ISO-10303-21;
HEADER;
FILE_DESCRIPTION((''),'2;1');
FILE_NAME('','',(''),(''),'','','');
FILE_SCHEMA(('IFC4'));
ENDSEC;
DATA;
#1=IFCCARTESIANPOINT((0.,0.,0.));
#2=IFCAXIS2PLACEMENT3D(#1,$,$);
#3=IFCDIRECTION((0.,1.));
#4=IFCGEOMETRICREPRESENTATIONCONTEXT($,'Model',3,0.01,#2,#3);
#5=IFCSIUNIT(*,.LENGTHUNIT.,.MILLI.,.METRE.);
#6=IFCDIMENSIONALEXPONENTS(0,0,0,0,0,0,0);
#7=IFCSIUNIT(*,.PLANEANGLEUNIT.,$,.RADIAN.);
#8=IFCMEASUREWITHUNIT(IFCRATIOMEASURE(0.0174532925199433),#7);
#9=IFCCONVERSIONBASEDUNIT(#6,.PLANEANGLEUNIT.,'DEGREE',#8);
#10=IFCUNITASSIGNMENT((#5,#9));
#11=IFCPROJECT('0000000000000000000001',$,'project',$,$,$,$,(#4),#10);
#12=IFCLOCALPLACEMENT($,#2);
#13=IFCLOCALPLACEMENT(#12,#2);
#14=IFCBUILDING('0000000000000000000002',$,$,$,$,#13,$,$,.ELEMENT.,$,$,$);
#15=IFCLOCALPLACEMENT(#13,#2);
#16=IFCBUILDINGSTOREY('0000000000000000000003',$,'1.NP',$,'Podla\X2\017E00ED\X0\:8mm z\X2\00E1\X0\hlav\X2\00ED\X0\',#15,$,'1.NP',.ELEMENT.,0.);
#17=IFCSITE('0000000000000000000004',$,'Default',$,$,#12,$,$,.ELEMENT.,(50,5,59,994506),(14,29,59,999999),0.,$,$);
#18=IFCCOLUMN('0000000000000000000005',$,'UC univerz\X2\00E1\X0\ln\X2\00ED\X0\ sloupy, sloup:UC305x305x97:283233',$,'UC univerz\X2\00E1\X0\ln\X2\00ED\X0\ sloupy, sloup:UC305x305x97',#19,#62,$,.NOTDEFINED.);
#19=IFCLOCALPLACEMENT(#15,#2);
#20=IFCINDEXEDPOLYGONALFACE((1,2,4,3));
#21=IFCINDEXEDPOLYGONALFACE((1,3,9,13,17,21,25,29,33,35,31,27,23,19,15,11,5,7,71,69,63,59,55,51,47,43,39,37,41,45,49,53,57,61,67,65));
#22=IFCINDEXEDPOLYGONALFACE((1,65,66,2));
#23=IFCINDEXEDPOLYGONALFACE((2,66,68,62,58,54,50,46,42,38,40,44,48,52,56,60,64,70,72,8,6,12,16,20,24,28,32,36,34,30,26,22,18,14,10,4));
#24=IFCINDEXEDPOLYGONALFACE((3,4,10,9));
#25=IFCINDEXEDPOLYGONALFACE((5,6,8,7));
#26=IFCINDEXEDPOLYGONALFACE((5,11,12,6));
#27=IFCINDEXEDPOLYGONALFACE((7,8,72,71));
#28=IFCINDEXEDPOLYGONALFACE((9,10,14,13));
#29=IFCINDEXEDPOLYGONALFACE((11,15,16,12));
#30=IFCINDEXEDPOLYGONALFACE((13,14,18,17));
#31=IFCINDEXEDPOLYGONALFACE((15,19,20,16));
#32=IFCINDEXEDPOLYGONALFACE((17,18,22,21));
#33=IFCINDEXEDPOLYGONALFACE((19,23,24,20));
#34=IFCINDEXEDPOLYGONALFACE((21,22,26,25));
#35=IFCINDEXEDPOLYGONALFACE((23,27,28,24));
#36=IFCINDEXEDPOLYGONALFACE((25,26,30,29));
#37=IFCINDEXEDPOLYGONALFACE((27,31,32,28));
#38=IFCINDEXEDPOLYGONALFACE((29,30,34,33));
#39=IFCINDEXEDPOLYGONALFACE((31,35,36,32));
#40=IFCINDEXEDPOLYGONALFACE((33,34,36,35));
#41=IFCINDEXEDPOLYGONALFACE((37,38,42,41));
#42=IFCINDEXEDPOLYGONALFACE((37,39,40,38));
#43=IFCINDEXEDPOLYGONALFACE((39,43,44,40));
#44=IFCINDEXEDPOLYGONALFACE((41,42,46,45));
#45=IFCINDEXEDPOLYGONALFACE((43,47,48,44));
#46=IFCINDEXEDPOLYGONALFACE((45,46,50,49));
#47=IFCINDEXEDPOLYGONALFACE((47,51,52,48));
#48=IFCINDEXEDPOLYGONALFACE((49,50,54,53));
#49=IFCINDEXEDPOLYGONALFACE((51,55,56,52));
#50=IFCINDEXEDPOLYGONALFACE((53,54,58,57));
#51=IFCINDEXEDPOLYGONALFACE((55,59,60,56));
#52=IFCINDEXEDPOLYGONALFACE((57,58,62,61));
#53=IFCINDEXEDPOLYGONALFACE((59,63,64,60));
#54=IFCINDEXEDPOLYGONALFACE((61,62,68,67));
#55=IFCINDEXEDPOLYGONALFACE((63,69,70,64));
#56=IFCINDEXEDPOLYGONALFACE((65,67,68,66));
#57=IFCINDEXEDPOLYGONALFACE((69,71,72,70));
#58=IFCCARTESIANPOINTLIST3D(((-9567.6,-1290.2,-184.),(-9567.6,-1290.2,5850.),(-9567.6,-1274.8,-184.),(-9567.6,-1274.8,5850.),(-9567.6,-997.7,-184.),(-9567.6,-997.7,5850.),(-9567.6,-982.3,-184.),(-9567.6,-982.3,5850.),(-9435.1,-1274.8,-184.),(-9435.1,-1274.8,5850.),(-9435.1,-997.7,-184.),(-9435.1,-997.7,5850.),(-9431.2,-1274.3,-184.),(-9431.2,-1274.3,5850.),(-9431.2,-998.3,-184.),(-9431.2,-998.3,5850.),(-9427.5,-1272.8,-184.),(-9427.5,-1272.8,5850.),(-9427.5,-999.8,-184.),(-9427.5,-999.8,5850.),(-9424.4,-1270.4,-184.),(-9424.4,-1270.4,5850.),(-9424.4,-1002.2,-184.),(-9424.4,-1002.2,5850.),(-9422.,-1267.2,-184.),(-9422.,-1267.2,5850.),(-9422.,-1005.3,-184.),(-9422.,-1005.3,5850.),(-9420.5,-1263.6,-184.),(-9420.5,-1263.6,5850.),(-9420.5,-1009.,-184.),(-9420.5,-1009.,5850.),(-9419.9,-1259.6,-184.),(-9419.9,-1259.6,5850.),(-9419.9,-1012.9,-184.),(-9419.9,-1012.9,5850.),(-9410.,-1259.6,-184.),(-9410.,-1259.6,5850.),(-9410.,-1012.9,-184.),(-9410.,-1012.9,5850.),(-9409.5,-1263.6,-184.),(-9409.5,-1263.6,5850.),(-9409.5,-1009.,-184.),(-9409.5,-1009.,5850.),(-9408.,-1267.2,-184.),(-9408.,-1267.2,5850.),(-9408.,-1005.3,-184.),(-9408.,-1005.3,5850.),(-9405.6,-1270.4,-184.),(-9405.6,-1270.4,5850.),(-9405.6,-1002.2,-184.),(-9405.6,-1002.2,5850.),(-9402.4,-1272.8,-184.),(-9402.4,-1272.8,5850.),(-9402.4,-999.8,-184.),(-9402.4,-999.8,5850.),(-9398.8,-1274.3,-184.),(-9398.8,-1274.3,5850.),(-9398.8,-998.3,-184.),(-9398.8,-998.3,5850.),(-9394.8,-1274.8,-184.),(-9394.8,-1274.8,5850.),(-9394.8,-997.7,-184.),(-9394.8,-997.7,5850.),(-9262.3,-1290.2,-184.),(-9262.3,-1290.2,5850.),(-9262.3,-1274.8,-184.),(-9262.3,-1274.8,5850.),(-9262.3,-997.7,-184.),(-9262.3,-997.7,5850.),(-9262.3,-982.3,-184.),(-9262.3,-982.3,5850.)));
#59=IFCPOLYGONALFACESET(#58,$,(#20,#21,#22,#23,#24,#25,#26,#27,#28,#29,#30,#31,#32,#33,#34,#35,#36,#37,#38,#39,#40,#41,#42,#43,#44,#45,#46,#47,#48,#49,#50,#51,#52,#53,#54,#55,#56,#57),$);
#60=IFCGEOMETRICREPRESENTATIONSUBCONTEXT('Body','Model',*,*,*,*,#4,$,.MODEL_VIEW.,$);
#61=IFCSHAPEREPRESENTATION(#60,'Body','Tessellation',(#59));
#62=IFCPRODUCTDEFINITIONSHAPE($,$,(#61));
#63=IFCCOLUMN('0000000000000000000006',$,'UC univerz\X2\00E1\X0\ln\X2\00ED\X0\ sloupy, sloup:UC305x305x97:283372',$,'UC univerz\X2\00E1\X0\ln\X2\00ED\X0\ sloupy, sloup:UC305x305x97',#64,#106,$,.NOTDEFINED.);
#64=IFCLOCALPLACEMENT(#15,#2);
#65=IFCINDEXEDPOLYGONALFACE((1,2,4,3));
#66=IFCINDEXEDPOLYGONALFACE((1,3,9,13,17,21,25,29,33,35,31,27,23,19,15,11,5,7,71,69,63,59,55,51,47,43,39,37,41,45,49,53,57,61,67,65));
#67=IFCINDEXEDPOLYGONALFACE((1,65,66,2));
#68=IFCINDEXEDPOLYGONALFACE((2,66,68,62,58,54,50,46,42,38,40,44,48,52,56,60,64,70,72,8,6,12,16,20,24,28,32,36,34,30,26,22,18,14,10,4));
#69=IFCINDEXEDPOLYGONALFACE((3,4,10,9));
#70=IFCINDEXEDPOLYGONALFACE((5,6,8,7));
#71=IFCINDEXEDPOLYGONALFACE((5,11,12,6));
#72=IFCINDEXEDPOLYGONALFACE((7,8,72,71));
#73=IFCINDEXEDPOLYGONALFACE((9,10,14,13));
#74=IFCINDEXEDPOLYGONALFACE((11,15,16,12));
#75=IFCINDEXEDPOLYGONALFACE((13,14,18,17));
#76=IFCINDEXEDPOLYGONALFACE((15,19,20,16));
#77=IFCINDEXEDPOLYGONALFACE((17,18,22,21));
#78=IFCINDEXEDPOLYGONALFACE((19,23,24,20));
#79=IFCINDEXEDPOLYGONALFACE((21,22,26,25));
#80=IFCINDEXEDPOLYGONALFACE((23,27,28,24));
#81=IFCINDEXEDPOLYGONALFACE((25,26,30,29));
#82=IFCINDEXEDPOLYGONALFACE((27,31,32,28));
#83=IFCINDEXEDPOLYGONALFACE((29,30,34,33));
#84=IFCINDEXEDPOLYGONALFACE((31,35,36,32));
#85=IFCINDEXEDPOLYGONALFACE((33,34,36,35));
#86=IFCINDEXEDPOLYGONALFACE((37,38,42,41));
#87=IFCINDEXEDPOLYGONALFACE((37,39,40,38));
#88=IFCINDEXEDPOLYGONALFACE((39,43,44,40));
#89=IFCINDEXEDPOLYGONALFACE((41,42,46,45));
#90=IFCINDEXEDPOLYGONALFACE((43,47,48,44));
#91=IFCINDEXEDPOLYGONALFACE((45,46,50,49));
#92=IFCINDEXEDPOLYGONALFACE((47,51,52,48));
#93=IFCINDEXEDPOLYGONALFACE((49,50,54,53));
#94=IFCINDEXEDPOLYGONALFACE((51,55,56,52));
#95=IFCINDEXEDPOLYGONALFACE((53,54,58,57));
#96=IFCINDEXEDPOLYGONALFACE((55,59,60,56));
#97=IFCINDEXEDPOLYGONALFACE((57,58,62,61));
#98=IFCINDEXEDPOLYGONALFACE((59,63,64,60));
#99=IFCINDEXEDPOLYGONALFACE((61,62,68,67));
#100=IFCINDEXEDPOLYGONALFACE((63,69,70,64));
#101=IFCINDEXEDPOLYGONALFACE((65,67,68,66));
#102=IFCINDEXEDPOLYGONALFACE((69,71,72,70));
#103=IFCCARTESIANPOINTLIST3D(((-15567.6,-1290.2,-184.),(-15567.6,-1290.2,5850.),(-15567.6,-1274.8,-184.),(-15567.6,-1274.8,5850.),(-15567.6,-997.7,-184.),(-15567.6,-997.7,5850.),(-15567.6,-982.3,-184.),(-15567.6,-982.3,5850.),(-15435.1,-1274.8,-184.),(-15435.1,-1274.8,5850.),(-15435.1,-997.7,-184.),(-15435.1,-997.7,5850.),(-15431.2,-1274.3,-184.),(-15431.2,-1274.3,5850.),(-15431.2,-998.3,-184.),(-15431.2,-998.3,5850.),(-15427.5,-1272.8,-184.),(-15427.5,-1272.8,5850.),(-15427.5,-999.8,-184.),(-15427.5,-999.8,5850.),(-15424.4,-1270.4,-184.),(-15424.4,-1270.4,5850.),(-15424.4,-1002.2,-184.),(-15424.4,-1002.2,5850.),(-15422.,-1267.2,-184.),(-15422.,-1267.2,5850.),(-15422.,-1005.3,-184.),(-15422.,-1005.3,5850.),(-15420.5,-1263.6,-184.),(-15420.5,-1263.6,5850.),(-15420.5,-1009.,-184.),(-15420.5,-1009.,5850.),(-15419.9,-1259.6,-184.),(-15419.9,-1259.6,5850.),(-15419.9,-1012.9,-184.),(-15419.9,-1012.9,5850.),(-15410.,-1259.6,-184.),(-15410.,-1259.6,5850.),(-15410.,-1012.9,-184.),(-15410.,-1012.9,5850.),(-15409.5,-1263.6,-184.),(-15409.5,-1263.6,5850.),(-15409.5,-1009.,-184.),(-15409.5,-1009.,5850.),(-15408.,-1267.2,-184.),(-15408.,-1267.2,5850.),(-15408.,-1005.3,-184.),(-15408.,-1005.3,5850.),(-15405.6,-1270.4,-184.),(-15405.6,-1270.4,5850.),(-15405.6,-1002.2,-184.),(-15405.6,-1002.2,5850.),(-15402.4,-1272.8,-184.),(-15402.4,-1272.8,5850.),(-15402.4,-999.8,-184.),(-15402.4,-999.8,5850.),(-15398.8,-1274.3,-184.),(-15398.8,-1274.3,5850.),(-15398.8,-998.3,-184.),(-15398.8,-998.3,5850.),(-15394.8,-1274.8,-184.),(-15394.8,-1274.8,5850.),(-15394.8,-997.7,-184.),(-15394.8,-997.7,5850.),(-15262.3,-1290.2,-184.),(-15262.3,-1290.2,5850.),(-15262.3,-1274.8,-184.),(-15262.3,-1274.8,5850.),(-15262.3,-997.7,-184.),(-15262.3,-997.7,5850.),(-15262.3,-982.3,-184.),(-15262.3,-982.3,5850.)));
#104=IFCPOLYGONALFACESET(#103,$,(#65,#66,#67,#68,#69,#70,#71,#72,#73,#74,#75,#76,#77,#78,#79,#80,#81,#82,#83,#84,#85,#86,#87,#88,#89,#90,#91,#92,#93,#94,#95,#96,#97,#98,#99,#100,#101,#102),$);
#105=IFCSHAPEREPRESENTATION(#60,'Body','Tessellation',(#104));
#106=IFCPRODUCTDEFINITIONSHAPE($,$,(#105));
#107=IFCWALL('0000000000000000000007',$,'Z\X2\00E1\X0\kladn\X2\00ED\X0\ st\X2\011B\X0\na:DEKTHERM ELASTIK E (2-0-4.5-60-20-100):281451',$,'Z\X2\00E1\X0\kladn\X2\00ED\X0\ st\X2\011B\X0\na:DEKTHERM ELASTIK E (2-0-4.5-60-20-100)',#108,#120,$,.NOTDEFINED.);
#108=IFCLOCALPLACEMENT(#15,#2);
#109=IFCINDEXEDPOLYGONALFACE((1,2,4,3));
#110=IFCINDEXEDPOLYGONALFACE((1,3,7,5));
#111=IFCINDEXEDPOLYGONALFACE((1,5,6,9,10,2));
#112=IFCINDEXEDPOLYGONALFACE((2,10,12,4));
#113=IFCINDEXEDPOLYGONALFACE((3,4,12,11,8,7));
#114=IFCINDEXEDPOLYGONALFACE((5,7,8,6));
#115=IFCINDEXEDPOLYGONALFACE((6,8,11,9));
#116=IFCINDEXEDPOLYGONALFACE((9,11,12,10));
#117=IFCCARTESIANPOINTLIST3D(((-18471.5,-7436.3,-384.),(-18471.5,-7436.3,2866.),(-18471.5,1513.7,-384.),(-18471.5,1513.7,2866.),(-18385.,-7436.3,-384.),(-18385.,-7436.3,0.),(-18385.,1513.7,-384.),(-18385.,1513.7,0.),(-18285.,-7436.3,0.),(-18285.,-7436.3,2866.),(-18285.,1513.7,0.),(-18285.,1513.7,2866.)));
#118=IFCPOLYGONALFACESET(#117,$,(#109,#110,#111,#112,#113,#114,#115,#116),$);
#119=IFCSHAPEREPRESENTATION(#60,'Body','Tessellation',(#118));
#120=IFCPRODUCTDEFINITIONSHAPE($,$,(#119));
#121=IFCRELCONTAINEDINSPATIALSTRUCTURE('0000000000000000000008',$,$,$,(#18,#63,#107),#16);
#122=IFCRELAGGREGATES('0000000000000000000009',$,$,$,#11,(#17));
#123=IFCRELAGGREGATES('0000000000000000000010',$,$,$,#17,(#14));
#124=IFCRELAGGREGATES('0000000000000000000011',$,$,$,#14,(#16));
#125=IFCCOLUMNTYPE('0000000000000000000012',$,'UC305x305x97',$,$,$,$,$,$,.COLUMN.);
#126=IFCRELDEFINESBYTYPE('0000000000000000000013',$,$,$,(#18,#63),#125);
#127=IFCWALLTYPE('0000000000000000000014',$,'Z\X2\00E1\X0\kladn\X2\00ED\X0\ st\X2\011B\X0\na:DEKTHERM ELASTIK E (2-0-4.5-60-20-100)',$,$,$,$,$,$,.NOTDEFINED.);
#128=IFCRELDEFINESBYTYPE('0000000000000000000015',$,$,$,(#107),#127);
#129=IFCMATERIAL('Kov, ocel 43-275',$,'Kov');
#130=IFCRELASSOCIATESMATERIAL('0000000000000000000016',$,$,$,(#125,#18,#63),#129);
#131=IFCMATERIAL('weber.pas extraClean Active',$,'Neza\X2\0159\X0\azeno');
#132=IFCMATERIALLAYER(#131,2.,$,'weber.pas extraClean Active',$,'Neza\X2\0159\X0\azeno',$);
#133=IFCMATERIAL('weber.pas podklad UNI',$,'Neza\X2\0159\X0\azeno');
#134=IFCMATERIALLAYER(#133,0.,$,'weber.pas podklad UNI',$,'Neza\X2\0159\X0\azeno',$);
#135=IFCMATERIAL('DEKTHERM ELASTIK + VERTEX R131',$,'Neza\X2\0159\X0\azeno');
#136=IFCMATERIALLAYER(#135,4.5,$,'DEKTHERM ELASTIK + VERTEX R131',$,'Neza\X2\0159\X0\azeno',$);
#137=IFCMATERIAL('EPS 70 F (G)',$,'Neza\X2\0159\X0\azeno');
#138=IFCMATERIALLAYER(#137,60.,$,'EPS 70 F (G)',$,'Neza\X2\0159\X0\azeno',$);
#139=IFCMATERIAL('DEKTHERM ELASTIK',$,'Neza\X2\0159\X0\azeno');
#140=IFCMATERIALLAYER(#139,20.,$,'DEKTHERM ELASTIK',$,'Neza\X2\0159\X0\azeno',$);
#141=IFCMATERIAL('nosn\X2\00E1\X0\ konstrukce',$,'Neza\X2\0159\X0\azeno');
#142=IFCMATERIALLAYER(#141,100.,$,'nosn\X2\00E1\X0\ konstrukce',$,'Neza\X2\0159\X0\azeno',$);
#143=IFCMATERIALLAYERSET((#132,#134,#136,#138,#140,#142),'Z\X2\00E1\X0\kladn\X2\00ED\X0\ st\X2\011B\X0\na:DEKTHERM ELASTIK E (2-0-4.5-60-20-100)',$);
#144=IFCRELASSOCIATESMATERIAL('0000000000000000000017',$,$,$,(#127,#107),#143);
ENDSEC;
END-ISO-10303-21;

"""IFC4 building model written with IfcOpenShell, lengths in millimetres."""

from ifc_helpers import new_model, entity, si_unit, converted_unit, direction, frame, frame_2d, origin, place, context, subcontext, project, spatial, polyline, rectangle, i_section, extrude, clip, bounded_halfspace, source, transform, mapped, material, layer, layer_set, layer_usage, material_profile, profile_set, profile_usage, type_object, type_shapes, element, save


model = new_model("IFC4")

# Units and contexts
model_context = context("Model", 3, precision=0.01, world=origin(), true_north=direction((0.0, 1.0)))
body_context = subcontext(model_context, "Body", "Model", "MODEL_VIEW")
ifc_project = project(units=[si_unit("LENGTHUNIT", "METRE", prefix="MILLI"), converted_unit("PLANEANGLEUNIT", "DEGREE", entity("IfcRatioMeasure", 0.0174532925199433), si_unit("PLANEANGLEUNIT", "RADIAN"), dimensions=[0, 0, 0, 0, 0, 0, 0])], contexts=[model_context])

# Site, building, storey
site_placement = place(None, origin())
site = spatial("IfcSite", under=ifc_project, at=site_placement, Name="Default", CompositionType="ELEMENT", RefLatitude=(50, 5, 59, 994506), RefLongitude=(14, 29, 59, 999999), RefElevation=0.0)
building_placement = place(site_placement, origin())
building = spatial("IfcBuilding", under=site, at=building_placement, CompositionType="ELEMENT")
storey_placement = place(building_placement, origin())
storey = spatial("IfcBuildingStorey", under=building, at=storey_placement, Name="1.NP", ObjectType="Podlaží:8mm záhlaví", LongName="1.NP", CompositionType="ELEMENT", Elevation=0.0)

# Columns
ifc_material_1 = material(Name="Kov, ocel 43-275", Category="Kov")
ifc_material_profile = material_profile(ifc_material_1, i_section(OverallWidth=305.3, OverallDepth=307.9, WebThickness=9.9, FlangeThickness=15.4, FilletRadius=15.2, at=frame_2d((0.0, 0.0), x_axis=(0.0, 1.0))), Name="UC305x305x97")
ifc_profile_set = profile_set([ifc_material_profile], Name="UC305x305x97")
ifc_profile_usage_1 = profile_usage(ifc_profile_set)
column_type = type_object("IfcColumnType", Name="UC305x305x97", PredefinedType="COLUMN", material=ifc_profile_set)
shared_shape_1 = source(origin(), body_context, "Body", "SweptSolid", [
    extrude(i_section(OverallWidth=305.3, OverallDepth=307.9, WebThickness=9.9, FlangeThickness=15.4, FilletRadius=15.2, at=frame_2d((0.0, 0.0), x_axis=(0.0, 1.0))), frame((0.0, 0.0, -184.0), z_axis=(0.0, 0.0, 1.0), x_axis=(0.0, -1.0, 0.0)), (0.0, 0.0, 1.0), 6034.0),
])
type_shapes(column_type, [shared_shape_1])
column_1_placement = place(storey_placement, frame((-9415.0, -1136.3, 0.0)))
element("IfcColumn", 1, at=column_1_placement, inside=storey, type_object=column_type, material=ifc_profile_usage_1, Name="UC univerzální sloupy, sloup:UC305x305x97:283233", ObjectType="UC univerzální sloupy, sloup:UC305x305x97", PredefinedType="NOTDEFINED", context=body_context, shape_type="MappedRepresentation", body=[
    mapped(shared_shape_1, transform((0.0, 0.0, 0.0), scale=1.0)),
])
ifc_profile_usage_2 = profile_usage(ifc_profile_set)
column_2_placement = place(storey_placement, frame((-15415.0, -1136.3, 0.0)))
element("IfcColumn", 2, at=column_2_placement, inside=storey, type_object=column_type, material=ifc_profile_usage_2, Name="UC univerzální sloupy, sloup:UC305x305x97:283372", ObjectType="UC univerzální sloupy, sloup:UC305x305x97", PredefinedType="NOTDEFINED", context=body_context, shape_type="MappedRepresentation", body=[
    mapped(shared_shape_1, transform((0.0, 0.0, 0.0), scale=1.0)),
])

# Wall
ifc_material_2 = material(Name="weber.pas extraClean Active", Category="Nezařazeno")
ifc_layer_1 = layer(ifc_material_2, 2.0, Name="weber.pas extraClean Active", Category="Nezařazeno")
ifc_material_3 = material(Name="weber.pas podklad UNI", Category="Nezařazeno")
ifc_layer_2 = layer(ifc_material_3, 0.0, Name="weber.pas podklad UNI", Category="Nezařazeno")
ifc_material_4 = material(Name="DEKTHERM ELASTIK + VERTEX R131", Category="Nezařazeno")
ifc_layer_3 = layer(ifc_material_4, 4.5, Name="DEKTHERM ELASTIK + VERTEX R131", Category="Nezařazeno")
ifc_material_5 = material(Name="EPS 70 F (G)", Category="Nezařazeno")
ifc_layer_4 = layer(ifc_material_5, 60.0, Name="EPS 70 F (G)", Category="Nezařazeno")
ifc_material_6 = material(Name="DEKTHERM ELASTIK", Category="Nezařazeno")
ifc_layer_5 = layer(ifc_material_6, 20.0, Name="DEKTHERM ELASTIK", Category="Nezařazeno")
ifc_material_7 = material(Name="nosná konstrukce", Category="Nezařazeno")
ifc_layer_6 = layer(ifc_material_7, 100.0, Name="nosná konstrukce", Category="Nezařazeno")
ifc_layer_set = layer_set([ifc_layer_1, ifc_layer_2, ifc_layer_3, ifc_layer_4, ifc_layer_5, ifc_layer_6], Name="Základní stěna:DEKTHERM ELASTIK E (2-0-4.5-60-20-100)")
wall_type = type_object("IfcWallType", Name="Základní stěna:DEKTHERM ELASTIK E (2-0-4.5-60-20-100)", PredefinedType="NOTDEFINED", material=ifc_layer_set)
ifc_layer_usage_1 = layer_usage(ifc_layer_set, "AXIS2", "POSITIVE", -93.2)
wall_1_placement = place(storey_placement, frame((-18378.2, 1513.7, -384.0), z_axis=(0.0, 0.0, 1.0), x_axis=(0.0, -1.0, 0.0)))
element("IfcWall", 3, at=wall_1_placement, inside=storey, type_object=wall_type, material=ifc_layer_usage_1, Name="Základní stěna:DEKTHERM ELASTIK E (2-0-4.5-60-20-100):281451", ObjectType="Základní stěna:DEKTHERM ELASTIK E (2-0-4.5-60-20-100)", PredefinedType="NOTDEFINED", context=body_context, shape_type="Clipping", body=[
    clip(clip(clip(extrude(rectangle(XDim=8950.0, YDim=186.5, at=frame_2d((4475.0, 0.0), x_axis=(-1.0, 0.0))), origin(), (0.0, 0.0, 1.0), 3250.0), bounded_halfspace(frame((8950.0, -6.8, 3250.0), z_axis=(0.0, 0.0, -1.0), x_axis=(1.0, 0.0, 0.0)), True, frame((8950.0, -6.8, 3250.0)), polyline([(0.0, 0.0), (0.0, 100.0), (-8950.0, 100.0), (-8950.0, 0.0), (0.0, 0.0)]))), bounded_halfspace(frame((8950.0, -6.8, 384.0), z_axis=(0.0, 0.0, 1.0), x_axis=(0.0, -1.0, 0.0)), True, frame((8950.0, -6.8, 384.0), z_axis=(0.0, 0.0, 1.0), x_axis=(0.0, -1.0, 0.0)), polyline([(0.0, 0.0), (-100.0, 0.0), (-100.0, -8950.0), (0.0, -8950.0), (0.0, 0.0)]))), bounded_halfspace(frame((0.0, -6.8, 384.0), z_axis=(0.0, -1.0, 0.0), x_axis=(0.0, 0.0, 1.0)), True, frame((0.0, -6.8, 384.0), z_axis=(0.0, -1.0, 0.0), x_axis=(0.0, 0.0, 1.0)), polyline([(0.0, 0.0), (-384.0, 0.0), (-384.0, -8950.0), (0.0, -8950.0), (0.0, 0.0)]))),
])

save(model, "model.ifc")
